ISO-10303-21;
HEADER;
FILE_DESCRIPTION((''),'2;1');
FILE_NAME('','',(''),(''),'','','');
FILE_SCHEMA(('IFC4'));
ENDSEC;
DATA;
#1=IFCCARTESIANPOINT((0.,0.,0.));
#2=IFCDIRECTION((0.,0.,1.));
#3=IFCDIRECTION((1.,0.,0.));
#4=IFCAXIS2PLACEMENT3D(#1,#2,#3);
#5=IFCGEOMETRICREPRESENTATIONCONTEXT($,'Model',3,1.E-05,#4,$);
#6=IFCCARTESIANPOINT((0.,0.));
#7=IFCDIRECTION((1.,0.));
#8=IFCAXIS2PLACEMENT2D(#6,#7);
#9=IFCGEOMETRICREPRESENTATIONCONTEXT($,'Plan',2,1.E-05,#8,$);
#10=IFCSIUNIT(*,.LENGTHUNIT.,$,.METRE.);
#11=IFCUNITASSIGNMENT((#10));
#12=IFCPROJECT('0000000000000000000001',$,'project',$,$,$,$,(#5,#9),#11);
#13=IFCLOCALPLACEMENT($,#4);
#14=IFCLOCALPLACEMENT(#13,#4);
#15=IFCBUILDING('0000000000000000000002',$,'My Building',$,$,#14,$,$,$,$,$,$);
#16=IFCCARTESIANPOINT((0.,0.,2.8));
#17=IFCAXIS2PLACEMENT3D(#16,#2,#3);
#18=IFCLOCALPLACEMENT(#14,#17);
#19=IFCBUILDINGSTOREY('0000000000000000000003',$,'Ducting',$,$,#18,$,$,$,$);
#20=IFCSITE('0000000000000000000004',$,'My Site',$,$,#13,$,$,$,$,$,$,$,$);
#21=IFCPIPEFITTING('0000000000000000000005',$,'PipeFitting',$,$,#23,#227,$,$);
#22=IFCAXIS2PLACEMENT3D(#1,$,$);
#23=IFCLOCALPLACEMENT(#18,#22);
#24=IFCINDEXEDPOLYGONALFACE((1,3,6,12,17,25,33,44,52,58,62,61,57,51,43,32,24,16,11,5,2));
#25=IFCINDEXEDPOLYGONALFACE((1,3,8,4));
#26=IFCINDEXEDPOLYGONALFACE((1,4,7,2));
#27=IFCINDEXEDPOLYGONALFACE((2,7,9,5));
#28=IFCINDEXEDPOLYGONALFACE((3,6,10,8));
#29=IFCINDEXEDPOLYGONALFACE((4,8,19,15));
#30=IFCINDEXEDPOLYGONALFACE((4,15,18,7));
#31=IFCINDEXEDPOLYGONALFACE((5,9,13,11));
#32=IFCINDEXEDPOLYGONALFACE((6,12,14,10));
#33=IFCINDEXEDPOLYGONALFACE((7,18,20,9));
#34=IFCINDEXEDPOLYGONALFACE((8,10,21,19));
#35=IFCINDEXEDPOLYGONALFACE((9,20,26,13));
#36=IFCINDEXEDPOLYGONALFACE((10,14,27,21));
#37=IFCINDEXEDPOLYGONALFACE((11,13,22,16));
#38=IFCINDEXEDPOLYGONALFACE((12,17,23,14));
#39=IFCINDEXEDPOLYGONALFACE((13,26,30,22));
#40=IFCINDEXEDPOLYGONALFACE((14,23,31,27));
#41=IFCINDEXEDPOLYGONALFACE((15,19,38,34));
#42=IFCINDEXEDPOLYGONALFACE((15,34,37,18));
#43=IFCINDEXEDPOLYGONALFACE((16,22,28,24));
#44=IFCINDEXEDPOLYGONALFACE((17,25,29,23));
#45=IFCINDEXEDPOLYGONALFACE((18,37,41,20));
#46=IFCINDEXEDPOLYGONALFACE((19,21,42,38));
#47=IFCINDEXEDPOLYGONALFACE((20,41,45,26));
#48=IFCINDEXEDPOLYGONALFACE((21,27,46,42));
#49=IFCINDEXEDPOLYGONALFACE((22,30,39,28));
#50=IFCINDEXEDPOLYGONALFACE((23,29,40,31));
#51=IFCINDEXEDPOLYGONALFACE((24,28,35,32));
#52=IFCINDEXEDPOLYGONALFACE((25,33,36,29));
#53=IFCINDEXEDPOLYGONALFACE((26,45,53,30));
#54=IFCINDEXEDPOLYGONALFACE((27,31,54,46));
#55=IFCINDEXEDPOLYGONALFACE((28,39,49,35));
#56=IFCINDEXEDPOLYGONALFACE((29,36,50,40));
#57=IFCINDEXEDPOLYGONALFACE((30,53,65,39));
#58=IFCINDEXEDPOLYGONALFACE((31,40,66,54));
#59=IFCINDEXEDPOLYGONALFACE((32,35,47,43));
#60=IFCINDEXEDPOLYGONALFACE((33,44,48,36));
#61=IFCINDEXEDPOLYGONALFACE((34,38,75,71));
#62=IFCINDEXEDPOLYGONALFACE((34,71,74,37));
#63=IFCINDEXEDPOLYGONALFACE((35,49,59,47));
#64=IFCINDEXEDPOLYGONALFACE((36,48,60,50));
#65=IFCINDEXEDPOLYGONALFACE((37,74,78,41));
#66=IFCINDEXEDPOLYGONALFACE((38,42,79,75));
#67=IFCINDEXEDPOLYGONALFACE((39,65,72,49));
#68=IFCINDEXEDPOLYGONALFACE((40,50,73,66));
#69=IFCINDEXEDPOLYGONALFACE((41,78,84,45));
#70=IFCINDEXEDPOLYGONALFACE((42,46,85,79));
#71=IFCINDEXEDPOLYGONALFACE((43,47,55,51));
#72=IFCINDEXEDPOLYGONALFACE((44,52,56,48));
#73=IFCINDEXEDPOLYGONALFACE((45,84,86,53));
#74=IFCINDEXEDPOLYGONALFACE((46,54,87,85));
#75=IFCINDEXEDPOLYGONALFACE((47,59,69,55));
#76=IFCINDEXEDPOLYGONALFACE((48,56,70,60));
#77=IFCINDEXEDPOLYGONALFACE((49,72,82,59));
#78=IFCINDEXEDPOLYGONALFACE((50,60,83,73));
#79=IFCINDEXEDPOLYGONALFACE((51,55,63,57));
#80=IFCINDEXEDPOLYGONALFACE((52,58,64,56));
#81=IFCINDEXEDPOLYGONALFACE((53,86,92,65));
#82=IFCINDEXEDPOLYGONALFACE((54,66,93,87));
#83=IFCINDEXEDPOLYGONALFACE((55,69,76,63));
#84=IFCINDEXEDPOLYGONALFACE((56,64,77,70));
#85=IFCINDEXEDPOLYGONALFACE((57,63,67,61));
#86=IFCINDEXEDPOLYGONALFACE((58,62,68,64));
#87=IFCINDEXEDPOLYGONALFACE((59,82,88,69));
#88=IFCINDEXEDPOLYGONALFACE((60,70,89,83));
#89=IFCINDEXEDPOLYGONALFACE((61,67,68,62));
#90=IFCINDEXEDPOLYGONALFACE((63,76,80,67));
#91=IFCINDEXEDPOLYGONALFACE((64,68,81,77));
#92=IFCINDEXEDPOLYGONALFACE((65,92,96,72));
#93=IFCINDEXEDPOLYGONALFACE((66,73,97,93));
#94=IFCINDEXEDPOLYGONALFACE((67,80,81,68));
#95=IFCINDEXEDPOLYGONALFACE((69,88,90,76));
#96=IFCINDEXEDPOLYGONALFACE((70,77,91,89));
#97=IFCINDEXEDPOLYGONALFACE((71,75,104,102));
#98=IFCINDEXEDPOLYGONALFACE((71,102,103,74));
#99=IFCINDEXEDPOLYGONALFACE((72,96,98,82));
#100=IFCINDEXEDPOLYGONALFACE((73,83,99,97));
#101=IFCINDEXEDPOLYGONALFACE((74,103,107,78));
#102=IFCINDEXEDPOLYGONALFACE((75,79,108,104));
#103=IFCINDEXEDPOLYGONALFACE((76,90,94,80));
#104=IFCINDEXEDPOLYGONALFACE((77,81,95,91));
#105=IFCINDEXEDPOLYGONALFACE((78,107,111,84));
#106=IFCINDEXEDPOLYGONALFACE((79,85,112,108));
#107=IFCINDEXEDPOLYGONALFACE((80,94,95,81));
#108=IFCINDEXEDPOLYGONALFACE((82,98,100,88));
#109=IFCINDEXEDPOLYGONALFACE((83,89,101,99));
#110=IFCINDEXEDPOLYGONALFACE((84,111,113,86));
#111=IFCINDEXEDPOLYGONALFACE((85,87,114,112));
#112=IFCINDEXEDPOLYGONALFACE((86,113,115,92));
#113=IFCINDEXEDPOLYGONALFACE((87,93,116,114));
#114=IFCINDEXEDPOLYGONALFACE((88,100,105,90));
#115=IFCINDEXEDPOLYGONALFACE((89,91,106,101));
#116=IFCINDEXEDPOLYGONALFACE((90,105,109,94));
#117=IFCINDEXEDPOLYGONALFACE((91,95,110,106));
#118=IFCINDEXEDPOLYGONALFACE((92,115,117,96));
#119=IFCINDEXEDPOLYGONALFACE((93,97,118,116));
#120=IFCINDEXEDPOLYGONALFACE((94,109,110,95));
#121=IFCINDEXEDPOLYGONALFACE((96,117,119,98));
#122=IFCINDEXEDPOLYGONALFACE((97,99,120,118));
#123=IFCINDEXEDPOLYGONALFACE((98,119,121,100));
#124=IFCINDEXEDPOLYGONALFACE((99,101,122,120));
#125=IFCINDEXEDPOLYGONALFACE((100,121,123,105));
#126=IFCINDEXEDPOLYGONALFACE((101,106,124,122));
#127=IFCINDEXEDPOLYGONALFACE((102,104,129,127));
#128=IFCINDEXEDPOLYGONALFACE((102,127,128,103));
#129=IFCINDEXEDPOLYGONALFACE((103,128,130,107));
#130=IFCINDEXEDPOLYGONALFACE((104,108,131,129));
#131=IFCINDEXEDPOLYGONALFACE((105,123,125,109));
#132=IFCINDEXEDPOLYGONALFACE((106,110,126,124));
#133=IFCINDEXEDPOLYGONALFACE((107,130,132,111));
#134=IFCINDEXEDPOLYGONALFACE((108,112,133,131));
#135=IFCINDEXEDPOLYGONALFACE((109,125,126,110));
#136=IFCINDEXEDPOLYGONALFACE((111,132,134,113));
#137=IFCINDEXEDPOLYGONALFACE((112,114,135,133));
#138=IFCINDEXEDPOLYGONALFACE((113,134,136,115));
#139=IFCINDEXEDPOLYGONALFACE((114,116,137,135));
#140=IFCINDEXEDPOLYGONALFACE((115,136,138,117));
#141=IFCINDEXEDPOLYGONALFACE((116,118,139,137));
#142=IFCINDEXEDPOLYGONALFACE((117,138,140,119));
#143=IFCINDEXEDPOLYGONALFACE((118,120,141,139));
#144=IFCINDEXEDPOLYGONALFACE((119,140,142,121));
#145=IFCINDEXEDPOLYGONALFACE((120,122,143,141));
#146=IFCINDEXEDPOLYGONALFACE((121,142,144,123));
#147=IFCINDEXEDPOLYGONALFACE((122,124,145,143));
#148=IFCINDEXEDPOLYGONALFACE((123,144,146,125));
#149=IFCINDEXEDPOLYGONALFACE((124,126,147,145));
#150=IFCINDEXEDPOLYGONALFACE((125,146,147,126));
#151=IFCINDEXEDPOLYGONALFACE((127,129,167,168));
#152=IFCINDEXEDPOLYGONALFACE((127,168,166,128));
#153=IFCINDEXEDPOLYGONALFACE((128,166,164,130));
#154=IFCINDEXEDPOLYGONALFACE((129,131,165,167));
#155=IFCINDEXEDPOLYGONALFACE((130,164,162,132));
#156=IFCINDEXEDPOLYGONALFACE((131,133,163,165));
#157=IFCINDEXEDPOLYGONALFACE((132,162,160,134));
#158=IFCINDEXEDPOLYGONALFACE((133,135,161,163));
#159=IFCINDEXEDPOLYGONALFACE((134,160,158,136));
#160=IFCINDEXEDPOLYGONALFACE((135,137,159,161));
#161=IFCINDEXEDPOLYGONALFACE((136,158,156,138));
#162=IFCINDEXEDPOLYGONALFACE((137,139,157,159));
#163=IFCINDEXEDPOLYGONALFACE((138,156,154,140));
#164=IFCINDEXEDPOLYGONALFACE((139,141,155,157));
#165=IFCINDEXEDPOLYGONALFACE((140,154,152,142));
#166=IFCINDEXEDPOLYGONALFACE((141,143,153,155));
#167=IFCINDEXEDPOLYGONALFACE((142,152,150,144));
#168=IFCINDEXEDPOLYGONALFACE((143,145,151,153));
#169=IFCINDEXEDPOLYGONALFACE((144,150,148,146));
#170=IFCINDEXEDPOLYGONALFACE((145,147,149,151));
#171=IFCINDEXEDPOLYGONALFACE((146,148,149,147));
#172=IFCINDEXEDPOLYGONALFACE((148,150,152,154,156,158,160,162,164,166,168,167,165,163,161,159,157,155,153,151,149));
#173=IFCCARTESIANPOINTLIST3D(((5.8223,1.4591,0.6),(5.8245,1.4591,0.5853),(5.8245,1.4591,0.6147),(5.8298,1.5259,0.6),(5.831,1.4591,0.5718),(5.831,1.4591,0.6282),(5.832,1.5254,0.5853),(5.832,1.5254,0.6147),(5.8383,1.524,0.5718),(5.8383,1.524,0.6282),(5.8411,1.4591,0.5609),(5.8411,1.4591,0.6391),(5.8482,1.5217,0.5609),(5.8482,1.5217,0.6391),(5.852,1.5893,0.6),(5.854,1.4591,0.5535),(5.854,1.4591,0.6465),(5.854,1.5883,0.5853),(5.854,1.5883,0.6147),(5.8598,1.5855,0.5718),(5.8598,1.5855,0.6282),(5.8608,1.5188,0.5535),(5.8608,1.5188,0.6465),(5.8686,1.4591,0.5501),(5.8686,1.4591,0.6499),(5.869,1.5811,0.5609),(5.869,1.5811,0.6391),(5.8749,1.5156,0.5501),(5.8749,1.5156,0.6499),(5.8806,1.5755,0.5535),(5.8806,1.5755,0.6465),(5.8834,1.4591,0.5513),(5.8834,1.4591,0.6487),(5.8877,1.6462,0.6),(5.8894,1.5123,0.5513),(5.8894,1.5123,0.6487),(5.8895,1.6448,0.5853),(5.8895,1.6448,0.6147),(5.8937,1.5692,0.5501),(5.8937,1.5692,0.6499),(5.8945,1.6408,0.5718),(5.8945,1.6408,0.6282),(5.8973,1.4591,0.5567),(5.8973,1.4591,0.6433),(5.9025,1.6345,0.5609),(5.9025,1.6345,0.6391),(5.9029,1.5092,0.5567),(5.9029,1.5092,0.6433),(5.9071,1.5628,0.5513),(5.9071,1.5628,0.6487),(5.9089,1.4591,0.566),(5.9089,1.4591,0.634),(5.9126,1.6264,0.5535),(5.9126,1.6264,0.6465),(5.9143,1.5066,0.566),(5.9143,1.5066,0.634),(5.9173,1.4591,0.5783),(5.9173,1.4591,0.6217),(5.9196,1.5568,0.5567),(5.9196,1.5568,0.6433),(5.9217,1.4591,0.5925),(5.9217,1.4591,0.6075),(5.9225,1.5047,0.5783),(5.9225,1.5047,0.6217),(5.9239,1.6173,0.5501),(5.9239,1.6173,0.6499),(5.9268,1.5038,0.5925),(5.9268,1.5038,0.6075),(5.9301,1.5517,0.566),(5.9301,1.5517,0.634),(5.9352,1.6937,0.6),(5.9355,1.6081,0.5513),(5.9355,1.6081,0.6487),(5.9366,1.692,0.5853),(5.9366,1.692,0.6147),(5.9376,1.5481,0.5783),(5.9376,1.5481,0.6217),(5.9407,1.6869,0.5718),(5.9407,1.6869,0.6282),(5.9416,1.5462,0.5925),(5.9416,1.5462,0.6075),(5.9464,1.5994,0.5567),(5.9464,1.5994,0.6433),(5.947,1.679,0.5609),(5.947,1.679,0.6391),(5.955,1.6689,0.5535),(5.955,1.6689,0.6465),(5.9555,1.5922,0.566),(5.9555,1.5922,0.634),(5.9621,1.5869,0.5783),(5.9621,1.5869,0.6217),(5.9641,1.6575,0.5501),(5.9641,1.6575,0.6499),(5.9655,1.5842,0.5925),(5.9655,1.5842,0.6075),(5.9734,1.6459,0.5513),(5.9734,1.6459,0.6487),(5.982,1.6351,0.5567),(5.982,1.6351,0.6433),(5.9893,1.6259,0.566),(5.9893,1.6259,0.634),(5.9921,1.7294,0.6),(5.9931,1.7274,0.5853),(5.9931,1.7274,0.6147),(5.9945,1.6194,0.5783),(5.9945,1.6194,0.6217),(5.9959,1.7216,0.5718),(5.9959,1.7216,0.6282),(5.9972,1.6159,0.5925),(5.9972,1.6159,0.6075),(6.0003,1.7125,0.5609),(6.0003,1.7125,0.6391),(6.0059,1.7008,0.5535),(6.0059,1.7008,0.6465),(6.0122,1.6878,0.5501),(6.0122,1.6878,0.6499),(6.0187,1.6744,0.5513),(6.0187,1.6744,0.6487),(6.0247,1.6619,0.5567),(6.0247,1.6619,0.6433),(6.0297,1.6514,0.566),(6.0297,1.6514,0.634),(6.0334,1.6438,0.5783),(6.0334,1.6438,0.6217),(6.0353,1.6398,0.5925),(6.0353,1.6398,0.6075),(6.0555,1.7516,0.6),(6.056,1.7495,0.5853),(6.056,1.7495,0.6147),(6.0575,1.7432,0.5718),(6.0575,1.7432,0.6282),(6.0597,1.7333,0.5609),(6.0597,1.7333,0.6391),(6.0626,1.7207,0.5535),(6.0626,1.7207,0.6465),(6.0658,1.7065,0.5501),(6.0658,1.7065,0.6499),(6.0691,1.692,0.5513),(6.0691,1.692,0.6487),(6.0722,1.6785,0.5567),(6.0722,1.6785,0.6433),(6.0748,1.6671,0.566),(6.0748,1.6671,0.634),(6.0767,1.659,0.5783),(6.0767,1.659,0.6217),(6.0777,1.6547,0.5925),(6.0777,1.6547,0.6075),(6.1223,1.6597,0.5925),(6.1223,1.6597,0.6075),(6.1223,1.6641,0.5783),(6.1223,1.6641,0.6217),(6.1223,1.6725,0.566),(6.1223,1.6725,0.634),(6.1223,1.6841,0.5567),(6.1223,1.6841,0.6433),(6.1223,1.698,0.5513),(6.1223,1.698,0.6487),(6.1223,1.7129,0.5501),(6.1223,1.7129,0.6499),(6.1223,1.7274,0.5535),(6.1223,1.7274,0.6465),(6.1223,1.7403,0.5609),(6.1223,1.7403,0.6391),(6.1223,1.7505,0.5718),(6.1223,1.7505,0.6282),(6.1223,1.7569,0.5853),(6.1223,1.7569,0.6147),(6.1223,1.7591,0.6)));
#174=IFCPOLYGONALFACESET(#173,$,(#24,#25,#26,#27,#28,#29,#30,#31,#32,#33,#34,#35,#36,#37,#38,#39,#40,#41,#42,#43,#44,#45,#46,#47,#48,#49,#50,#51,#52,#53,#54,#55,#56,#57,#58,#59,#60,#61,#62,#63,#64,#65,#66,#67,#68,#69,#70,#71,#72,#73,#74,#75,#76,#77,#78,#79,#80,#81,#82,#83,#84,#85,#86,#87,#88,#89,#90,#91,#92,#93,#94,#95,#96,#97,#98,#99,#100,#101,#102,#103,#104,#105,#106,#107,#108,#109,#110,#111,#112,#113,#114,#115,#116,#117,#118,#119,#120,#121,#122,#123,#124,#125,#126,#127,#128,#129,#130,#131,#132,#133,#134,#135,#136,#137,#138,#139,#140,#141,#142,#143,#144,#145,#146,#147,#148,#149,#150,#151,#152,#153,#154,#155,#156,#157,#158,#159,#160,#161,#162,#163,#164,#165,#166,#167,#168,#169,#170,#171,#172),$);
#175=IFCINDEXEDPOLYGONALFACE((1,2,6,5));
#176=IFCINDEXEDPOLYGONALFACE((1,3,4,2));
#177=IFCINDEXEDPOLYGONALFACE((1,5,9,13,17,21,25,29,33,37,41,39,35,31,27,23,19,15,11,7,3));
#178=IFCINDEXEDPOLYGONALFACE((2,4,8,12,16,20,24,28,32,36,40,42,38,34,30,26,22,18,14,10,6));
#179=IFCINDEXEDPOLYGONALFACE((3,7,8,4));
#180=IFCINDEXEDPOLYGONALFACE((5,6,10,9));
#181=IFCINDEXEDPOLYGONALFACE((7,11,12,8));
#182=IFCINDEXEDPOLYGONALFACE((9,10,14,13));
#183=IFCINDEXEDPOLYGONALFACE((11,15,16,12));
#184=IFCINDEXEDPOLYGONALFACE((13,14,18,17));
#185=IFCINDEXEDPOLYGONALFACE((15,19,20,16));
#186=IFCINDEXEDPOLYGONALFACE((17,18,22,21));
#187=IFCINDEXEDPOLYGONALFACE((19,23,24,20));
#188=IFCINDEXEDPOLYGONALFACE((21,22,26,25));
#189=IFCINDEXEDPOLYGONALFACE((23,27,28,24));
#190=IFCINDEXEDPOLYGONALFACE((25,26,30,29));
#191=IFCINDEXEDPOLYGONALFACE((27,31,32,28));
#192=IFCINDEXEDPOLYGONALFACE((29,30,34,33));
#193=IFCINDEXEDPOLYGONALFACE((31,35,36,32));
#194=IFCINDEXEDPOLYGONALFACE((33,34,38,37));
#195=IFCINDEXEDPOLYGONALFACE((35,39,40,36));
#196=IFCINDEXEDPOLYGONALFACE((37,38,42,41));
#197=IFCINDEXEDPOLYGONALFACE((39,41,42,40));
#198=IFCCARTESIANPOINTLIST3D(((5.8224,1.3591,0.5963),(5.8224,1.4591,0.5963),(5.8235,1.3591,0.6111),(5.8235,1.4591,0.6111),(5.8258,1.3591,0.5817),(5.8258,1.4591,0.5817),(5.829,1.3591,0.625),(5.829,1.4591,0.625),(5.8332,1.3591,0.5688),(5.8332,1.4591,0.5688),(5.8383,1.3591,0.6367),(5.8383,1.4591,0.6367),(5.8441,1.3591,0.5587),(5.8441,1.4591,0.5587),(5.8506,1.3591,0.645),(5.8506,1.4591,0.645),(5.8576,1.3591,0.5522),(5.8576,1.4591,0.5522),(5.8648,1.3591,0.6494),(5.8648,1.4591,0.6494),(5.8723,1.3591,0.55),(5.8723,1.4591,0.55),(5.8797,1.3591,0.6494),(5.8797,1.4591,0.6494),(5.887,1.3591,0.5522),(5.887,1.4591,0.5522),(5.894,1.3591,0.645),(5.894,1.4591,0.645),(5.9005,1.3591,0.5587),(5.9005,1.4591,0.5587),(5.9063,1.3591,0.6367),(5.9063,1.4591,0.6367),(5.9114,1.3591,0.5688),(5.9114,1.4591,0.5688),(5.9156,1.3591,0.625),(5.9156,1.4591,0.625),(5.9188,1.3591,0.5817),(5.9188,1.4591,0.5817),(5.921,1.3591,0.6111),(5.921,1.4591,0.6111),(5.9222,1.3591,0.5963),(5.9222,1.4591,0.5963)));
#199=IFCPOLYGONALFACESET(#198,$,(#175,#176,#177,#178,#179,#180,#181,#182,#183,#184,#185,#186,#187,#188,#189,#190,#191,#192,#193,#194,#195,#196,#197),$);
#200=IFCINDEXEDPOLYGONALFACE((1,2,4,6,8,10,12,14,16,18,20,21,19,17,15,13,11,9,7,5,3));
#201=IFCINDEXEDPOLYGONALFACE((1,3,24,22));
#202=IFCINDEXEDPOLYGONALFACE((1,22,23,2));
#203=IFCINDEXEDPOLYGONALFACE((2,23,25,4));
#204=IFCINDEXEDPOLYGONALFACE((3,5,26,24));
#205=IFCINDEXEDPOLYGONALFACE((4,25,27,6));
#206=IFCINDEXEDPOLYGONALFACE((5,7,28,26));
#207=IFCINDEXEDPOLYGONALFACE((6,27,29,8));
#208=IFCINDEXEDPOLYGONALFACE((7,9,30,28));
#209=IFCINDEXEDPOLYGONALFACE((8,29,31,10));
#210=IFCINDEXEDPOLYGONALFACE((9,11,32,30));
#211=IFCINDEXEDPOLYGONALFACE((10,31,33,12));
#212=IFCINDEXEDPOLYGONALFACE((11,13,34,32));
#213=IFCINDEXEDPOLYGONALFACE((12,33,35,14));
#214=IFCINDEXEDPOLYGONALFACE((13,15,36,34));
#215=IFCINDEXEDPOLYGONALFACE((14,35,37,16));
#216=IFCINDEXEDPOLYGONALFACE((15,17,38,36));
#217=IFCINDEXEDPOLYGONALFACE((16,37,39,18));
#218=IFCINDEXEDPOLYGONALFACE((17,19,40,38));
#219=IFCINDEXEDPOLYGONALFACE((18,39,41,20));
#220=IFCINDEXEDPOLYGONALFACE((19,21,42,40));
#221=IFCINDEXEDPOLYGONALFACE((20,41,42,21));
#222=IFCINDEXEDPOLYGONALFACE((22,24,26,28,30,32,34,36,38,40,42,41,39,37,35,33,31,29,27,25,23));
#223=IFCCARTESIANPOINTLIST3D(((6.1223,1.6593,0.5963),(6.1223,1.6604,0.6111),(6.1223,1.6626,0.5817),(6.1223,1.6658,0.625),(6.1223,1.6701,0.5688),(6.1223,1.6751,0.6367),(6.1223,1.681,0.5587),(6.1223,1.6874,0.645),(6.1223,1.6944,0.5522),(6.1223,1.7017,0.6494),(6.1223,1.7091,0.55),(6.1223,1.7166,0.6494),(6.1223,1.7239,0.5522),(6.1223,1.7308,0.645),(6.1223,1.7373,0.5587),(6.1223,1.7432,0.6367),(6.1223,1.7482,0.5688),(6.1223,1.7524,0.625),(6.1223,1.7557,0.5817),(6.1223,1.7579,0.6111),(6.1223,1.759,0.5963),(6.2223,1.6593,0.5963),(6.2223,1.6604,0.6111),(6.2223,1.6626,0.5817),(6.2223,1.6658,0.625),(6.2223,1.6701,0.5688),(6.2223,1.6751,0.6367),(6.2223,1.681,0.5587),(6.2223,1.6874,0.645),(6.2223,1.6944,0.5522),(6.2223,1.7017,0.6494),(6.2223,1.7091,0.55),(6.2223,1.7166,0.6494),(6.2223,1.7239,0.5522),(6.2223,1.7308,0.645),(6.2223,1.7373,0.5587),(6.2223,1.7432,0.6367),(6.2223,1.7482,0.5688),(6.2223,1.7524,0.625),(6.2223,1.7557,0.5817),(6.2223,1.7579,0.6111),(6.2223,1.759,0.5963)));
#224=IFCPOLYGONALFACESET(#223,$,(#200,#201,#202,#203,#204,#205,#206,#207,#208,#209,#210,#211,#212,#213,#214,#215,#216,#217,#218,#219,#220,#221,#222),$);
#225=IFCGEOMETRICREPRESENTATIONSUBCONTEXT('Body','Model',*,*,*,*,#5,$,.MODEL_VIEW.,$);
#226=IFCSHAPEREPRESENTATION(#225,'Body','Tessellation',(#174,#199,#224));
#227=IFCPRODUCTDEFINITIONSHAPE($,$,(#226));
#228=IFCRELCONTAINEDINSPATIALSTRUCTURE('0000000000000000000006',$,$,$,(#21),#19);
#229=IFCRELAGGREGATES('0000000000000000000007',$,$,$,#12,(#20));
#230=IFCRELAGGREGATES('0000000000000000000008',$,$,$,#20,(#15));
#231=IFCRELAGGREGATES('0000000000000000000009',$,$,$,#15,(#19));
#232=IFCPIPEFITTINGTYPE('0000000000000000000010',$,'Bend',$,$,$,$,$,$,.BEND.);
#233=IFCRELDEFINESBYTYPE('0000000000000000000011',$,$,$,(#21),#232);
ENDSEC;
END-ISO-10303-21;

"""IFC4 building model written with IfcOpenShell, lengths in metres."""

from ifc_helpers import new_model, entity, si_unit, frame, origin_with_axes, origin_2d_with_axis, place, context, subcontext, project, spatial, circle, extrude, source, transform, mapped, type_object, type_shapes, element, save


model = new_model("IFC4")

# Units and contexts
model_context = context("Model", 3, precision=1e-05, world=origin_with_axes())
plan_context = context("Plan", 2, precision=1e-05, world=origin_2d_with_axis())
body_context = subcontext(model_context, "Body", "Model", "MODEL_VIEW")
ifc_project = project(units=[si_unit("LENGTHUNIT", "METRE")], contexts=[model_context, plan_context])

# Site, building, storey
site_placement = place(None, origin_with_axes())
site = spatial("IfcSite", under=ifc_project, at=site_placement, Name="My Site")
building_placement = place(site_placement, origin_with_axes())
building = spatial("IfcBuilding", under=site, at=building_placement, Name="My Building")
storey_placement = place(building_placement, frame((0.0, 0.0, 2.8), z_axis=(0.0, 0.0, 1.0), x_axis=(1.0, 0.0, 0.0)))
storey = spatial("IfcBuildingStorey", under=building, at=storey_placement, Name="Ducting")

# Pipe fitting
pipe_fitting_type = type_object("IfcPipeFittingType", Name="Bend", PredefinedType="BEND")
shared_shape_1 = source(origin_with_axes(), body_context, "Body", "SolidModel", [
    entity("IfcSweptDiskSolid", entity("IfcIndexedPolyCurve", entity("IfcCartesianPointList3D", [[0.0, 0.0, 0.1], [0.0, -0.0732, 0.2768], [0.0, -0.25, 0.35]]), [entity("IfcArcIndex", [1, 2, 3])]), 0.05),
    extrude(circle(Radius=0.05), origin_with_axes(), (0.0, 0.0, 1.0), 0.1),
    extrude(circle(Radius=0.05), frame((0.0, -0.25, 0.35), z_axis=(0.0, -1.0, 0.0), x_axis=(1.0, 0.0, 0.0)), (0.0, 0.0, 1.0), 0.1),
])
type_shapes(pipe_fitting_type, [shared_shape_1])
for number, where, z_axis, x_axis, name in (
    (1, (5.8723, 1.3591, 0.6), (0.0, 1.0, 0.0), (0.0, 0.0, -1.0), "PipeFitting"),
):
    element("IfcPipeFitting", number, at=place(storey_placement, frame(where, z_axis=z_axis, x_axis=x_axis)), inside=storey, type_object=pipe_fitting_type, Name=name, context=body_context, shape_type="MappedRepresentation", body=[
        mapped(shared_shape_1, transform((0.0, 0.0, 0.0), x_axis=(1.0, 0.0, 0.0), y_axis=(0.0, 1.0, 0.0), z_axis=(0.0, 0.0, 1.0), scale=1.0)),
    ])

save(model, "model.ifc")
